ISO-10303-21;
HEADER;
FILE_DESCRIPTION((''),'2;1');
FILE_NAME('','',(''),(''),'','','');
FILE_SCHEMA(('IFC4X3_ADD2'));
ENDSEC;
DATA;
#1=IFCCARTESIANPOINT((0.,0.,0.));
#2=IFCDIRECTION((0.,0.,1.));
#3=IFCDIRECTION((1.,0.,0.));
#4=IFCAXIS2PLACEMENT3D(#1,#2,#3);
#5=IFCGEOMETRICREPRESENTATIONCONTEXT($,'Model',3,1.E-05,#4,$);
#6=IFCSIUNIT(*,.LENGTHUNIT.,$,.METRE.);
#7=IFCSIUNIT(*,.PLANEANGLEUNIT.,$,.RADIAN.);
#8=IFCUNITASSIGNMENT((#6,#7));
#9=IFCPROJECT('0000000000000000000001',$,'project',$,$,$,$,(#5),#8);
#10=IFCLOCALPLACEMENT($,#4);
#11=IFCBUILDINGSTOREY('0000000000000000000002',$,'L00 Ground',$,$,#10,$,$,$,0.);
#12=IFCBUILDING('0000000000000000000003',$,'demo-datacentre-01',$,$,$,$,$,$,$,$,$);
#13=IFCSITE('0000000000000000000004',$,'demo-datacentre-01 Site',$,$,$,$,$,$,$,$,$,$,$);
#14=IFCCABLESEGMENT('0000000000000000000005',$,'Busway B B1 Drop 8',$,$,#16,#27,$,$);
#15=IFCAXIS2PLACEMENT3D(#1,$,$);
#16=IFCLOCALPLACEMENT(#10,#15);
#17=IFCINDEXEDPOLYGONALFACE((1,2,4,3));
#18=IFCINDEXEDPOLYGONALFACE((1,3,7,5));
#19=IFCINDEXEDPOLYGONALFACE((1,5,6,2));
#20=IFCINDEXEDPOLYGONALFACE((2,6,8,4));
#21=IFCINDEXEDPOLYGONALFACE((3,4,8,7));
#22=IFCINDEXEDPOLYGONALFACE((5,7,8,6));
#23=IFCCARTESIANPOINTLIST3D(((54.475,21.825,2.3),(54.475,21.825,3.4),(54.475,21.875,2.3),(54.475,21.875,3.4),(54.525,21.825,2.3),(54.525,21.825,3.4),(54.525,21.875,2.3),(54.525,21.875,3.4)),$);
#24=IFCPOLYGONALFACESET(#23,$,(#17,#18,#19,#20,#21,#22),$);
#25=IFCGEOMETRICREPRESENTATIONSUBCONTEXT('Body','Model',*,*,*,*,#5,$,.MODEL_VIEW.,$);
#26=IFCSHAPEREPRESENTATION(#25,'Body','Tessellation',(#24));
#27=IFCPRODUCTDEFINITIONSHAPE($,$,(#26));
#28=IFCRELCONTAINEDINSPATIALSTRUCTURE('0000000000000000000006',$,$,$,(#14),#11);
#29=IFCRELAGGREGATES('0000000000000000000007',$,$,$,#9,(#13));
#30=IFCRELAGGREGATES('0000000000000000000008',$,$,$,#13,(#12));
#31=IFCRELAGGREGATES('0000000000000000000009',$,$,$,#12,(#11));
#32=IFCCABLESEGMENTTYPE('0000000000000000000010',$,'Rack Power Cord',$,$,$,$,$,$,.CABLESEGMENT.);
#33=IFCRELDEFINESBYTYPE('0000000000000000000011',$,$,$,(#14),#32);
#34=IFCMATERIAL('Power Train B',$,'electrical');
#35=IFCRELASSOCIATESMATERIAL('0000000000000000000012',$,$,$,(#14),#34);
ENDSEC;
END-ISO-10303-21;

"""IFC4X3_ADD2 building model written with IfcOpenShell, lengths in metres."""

from ifc_helpers import new_model, si_unit, frame, origin_with_axes, place, context, subcontext, project, spatial, rectangle, extrude, material, type_object, element, save


model = new_model("IFC4X3_ADD2")

# Units and contexts
model_context = context("Model", 3, precision=1e-05, world=origin_with_axes())
body_context = subcontext(model_context, "Body", "Model", "MODEL_VIEW")
ifc_project = project(units=[si_unit("LENGTHUNIT", "METRE"), si_unit("PLANEANGLEUNIT", "RADIAN")], contexts=[model_context])

# Site, building, storey
site = spatial("IfcSite", under=ifc_project, Name="demo-datacentre-01 Site")
building = spatial("IfcBuilding", under=site, Name="demo-datacentre-01")
storey_placement = place(None, origin_with_axes())
storey = spatial("IfcBuildingStorey", under=building, at=storey_placement, Name="L00 Ground", Elevation=0.0)

# Shared definitions
ifc_material_1 = material(Name="Power Train B", Category="electrical")

# Cable segment
cable_segment_type_1 = type_object("IfcCableSegmentType", Name="Rack Power Cord", PredefinedType="CABLESEGMENT")
for number, where, z_axis, x_axis, name in (
    (1, (54.5, 21.85, 3.4), (0.0, 0.0, -1.0), (1.0, 0.0, 0.0), "Busway B B1 Drop 8"),
):
    element("IfcCableSegment", number, at=place(storey_placement, frame(where, z_axis=z_axis, x_axis=x_axis)), inside=storey, type_object=cable_segment_type_1, material=ifc_material_1, Name=name, context=body_context, shape_type="SweptSolid", body=[
        extrude(rectangle(XDim=0.05, YDim=0.05), origin_with_axes(), (0.0, 0.0, 1.0), 1.1),
    ])

save(model, "model.ifc")
